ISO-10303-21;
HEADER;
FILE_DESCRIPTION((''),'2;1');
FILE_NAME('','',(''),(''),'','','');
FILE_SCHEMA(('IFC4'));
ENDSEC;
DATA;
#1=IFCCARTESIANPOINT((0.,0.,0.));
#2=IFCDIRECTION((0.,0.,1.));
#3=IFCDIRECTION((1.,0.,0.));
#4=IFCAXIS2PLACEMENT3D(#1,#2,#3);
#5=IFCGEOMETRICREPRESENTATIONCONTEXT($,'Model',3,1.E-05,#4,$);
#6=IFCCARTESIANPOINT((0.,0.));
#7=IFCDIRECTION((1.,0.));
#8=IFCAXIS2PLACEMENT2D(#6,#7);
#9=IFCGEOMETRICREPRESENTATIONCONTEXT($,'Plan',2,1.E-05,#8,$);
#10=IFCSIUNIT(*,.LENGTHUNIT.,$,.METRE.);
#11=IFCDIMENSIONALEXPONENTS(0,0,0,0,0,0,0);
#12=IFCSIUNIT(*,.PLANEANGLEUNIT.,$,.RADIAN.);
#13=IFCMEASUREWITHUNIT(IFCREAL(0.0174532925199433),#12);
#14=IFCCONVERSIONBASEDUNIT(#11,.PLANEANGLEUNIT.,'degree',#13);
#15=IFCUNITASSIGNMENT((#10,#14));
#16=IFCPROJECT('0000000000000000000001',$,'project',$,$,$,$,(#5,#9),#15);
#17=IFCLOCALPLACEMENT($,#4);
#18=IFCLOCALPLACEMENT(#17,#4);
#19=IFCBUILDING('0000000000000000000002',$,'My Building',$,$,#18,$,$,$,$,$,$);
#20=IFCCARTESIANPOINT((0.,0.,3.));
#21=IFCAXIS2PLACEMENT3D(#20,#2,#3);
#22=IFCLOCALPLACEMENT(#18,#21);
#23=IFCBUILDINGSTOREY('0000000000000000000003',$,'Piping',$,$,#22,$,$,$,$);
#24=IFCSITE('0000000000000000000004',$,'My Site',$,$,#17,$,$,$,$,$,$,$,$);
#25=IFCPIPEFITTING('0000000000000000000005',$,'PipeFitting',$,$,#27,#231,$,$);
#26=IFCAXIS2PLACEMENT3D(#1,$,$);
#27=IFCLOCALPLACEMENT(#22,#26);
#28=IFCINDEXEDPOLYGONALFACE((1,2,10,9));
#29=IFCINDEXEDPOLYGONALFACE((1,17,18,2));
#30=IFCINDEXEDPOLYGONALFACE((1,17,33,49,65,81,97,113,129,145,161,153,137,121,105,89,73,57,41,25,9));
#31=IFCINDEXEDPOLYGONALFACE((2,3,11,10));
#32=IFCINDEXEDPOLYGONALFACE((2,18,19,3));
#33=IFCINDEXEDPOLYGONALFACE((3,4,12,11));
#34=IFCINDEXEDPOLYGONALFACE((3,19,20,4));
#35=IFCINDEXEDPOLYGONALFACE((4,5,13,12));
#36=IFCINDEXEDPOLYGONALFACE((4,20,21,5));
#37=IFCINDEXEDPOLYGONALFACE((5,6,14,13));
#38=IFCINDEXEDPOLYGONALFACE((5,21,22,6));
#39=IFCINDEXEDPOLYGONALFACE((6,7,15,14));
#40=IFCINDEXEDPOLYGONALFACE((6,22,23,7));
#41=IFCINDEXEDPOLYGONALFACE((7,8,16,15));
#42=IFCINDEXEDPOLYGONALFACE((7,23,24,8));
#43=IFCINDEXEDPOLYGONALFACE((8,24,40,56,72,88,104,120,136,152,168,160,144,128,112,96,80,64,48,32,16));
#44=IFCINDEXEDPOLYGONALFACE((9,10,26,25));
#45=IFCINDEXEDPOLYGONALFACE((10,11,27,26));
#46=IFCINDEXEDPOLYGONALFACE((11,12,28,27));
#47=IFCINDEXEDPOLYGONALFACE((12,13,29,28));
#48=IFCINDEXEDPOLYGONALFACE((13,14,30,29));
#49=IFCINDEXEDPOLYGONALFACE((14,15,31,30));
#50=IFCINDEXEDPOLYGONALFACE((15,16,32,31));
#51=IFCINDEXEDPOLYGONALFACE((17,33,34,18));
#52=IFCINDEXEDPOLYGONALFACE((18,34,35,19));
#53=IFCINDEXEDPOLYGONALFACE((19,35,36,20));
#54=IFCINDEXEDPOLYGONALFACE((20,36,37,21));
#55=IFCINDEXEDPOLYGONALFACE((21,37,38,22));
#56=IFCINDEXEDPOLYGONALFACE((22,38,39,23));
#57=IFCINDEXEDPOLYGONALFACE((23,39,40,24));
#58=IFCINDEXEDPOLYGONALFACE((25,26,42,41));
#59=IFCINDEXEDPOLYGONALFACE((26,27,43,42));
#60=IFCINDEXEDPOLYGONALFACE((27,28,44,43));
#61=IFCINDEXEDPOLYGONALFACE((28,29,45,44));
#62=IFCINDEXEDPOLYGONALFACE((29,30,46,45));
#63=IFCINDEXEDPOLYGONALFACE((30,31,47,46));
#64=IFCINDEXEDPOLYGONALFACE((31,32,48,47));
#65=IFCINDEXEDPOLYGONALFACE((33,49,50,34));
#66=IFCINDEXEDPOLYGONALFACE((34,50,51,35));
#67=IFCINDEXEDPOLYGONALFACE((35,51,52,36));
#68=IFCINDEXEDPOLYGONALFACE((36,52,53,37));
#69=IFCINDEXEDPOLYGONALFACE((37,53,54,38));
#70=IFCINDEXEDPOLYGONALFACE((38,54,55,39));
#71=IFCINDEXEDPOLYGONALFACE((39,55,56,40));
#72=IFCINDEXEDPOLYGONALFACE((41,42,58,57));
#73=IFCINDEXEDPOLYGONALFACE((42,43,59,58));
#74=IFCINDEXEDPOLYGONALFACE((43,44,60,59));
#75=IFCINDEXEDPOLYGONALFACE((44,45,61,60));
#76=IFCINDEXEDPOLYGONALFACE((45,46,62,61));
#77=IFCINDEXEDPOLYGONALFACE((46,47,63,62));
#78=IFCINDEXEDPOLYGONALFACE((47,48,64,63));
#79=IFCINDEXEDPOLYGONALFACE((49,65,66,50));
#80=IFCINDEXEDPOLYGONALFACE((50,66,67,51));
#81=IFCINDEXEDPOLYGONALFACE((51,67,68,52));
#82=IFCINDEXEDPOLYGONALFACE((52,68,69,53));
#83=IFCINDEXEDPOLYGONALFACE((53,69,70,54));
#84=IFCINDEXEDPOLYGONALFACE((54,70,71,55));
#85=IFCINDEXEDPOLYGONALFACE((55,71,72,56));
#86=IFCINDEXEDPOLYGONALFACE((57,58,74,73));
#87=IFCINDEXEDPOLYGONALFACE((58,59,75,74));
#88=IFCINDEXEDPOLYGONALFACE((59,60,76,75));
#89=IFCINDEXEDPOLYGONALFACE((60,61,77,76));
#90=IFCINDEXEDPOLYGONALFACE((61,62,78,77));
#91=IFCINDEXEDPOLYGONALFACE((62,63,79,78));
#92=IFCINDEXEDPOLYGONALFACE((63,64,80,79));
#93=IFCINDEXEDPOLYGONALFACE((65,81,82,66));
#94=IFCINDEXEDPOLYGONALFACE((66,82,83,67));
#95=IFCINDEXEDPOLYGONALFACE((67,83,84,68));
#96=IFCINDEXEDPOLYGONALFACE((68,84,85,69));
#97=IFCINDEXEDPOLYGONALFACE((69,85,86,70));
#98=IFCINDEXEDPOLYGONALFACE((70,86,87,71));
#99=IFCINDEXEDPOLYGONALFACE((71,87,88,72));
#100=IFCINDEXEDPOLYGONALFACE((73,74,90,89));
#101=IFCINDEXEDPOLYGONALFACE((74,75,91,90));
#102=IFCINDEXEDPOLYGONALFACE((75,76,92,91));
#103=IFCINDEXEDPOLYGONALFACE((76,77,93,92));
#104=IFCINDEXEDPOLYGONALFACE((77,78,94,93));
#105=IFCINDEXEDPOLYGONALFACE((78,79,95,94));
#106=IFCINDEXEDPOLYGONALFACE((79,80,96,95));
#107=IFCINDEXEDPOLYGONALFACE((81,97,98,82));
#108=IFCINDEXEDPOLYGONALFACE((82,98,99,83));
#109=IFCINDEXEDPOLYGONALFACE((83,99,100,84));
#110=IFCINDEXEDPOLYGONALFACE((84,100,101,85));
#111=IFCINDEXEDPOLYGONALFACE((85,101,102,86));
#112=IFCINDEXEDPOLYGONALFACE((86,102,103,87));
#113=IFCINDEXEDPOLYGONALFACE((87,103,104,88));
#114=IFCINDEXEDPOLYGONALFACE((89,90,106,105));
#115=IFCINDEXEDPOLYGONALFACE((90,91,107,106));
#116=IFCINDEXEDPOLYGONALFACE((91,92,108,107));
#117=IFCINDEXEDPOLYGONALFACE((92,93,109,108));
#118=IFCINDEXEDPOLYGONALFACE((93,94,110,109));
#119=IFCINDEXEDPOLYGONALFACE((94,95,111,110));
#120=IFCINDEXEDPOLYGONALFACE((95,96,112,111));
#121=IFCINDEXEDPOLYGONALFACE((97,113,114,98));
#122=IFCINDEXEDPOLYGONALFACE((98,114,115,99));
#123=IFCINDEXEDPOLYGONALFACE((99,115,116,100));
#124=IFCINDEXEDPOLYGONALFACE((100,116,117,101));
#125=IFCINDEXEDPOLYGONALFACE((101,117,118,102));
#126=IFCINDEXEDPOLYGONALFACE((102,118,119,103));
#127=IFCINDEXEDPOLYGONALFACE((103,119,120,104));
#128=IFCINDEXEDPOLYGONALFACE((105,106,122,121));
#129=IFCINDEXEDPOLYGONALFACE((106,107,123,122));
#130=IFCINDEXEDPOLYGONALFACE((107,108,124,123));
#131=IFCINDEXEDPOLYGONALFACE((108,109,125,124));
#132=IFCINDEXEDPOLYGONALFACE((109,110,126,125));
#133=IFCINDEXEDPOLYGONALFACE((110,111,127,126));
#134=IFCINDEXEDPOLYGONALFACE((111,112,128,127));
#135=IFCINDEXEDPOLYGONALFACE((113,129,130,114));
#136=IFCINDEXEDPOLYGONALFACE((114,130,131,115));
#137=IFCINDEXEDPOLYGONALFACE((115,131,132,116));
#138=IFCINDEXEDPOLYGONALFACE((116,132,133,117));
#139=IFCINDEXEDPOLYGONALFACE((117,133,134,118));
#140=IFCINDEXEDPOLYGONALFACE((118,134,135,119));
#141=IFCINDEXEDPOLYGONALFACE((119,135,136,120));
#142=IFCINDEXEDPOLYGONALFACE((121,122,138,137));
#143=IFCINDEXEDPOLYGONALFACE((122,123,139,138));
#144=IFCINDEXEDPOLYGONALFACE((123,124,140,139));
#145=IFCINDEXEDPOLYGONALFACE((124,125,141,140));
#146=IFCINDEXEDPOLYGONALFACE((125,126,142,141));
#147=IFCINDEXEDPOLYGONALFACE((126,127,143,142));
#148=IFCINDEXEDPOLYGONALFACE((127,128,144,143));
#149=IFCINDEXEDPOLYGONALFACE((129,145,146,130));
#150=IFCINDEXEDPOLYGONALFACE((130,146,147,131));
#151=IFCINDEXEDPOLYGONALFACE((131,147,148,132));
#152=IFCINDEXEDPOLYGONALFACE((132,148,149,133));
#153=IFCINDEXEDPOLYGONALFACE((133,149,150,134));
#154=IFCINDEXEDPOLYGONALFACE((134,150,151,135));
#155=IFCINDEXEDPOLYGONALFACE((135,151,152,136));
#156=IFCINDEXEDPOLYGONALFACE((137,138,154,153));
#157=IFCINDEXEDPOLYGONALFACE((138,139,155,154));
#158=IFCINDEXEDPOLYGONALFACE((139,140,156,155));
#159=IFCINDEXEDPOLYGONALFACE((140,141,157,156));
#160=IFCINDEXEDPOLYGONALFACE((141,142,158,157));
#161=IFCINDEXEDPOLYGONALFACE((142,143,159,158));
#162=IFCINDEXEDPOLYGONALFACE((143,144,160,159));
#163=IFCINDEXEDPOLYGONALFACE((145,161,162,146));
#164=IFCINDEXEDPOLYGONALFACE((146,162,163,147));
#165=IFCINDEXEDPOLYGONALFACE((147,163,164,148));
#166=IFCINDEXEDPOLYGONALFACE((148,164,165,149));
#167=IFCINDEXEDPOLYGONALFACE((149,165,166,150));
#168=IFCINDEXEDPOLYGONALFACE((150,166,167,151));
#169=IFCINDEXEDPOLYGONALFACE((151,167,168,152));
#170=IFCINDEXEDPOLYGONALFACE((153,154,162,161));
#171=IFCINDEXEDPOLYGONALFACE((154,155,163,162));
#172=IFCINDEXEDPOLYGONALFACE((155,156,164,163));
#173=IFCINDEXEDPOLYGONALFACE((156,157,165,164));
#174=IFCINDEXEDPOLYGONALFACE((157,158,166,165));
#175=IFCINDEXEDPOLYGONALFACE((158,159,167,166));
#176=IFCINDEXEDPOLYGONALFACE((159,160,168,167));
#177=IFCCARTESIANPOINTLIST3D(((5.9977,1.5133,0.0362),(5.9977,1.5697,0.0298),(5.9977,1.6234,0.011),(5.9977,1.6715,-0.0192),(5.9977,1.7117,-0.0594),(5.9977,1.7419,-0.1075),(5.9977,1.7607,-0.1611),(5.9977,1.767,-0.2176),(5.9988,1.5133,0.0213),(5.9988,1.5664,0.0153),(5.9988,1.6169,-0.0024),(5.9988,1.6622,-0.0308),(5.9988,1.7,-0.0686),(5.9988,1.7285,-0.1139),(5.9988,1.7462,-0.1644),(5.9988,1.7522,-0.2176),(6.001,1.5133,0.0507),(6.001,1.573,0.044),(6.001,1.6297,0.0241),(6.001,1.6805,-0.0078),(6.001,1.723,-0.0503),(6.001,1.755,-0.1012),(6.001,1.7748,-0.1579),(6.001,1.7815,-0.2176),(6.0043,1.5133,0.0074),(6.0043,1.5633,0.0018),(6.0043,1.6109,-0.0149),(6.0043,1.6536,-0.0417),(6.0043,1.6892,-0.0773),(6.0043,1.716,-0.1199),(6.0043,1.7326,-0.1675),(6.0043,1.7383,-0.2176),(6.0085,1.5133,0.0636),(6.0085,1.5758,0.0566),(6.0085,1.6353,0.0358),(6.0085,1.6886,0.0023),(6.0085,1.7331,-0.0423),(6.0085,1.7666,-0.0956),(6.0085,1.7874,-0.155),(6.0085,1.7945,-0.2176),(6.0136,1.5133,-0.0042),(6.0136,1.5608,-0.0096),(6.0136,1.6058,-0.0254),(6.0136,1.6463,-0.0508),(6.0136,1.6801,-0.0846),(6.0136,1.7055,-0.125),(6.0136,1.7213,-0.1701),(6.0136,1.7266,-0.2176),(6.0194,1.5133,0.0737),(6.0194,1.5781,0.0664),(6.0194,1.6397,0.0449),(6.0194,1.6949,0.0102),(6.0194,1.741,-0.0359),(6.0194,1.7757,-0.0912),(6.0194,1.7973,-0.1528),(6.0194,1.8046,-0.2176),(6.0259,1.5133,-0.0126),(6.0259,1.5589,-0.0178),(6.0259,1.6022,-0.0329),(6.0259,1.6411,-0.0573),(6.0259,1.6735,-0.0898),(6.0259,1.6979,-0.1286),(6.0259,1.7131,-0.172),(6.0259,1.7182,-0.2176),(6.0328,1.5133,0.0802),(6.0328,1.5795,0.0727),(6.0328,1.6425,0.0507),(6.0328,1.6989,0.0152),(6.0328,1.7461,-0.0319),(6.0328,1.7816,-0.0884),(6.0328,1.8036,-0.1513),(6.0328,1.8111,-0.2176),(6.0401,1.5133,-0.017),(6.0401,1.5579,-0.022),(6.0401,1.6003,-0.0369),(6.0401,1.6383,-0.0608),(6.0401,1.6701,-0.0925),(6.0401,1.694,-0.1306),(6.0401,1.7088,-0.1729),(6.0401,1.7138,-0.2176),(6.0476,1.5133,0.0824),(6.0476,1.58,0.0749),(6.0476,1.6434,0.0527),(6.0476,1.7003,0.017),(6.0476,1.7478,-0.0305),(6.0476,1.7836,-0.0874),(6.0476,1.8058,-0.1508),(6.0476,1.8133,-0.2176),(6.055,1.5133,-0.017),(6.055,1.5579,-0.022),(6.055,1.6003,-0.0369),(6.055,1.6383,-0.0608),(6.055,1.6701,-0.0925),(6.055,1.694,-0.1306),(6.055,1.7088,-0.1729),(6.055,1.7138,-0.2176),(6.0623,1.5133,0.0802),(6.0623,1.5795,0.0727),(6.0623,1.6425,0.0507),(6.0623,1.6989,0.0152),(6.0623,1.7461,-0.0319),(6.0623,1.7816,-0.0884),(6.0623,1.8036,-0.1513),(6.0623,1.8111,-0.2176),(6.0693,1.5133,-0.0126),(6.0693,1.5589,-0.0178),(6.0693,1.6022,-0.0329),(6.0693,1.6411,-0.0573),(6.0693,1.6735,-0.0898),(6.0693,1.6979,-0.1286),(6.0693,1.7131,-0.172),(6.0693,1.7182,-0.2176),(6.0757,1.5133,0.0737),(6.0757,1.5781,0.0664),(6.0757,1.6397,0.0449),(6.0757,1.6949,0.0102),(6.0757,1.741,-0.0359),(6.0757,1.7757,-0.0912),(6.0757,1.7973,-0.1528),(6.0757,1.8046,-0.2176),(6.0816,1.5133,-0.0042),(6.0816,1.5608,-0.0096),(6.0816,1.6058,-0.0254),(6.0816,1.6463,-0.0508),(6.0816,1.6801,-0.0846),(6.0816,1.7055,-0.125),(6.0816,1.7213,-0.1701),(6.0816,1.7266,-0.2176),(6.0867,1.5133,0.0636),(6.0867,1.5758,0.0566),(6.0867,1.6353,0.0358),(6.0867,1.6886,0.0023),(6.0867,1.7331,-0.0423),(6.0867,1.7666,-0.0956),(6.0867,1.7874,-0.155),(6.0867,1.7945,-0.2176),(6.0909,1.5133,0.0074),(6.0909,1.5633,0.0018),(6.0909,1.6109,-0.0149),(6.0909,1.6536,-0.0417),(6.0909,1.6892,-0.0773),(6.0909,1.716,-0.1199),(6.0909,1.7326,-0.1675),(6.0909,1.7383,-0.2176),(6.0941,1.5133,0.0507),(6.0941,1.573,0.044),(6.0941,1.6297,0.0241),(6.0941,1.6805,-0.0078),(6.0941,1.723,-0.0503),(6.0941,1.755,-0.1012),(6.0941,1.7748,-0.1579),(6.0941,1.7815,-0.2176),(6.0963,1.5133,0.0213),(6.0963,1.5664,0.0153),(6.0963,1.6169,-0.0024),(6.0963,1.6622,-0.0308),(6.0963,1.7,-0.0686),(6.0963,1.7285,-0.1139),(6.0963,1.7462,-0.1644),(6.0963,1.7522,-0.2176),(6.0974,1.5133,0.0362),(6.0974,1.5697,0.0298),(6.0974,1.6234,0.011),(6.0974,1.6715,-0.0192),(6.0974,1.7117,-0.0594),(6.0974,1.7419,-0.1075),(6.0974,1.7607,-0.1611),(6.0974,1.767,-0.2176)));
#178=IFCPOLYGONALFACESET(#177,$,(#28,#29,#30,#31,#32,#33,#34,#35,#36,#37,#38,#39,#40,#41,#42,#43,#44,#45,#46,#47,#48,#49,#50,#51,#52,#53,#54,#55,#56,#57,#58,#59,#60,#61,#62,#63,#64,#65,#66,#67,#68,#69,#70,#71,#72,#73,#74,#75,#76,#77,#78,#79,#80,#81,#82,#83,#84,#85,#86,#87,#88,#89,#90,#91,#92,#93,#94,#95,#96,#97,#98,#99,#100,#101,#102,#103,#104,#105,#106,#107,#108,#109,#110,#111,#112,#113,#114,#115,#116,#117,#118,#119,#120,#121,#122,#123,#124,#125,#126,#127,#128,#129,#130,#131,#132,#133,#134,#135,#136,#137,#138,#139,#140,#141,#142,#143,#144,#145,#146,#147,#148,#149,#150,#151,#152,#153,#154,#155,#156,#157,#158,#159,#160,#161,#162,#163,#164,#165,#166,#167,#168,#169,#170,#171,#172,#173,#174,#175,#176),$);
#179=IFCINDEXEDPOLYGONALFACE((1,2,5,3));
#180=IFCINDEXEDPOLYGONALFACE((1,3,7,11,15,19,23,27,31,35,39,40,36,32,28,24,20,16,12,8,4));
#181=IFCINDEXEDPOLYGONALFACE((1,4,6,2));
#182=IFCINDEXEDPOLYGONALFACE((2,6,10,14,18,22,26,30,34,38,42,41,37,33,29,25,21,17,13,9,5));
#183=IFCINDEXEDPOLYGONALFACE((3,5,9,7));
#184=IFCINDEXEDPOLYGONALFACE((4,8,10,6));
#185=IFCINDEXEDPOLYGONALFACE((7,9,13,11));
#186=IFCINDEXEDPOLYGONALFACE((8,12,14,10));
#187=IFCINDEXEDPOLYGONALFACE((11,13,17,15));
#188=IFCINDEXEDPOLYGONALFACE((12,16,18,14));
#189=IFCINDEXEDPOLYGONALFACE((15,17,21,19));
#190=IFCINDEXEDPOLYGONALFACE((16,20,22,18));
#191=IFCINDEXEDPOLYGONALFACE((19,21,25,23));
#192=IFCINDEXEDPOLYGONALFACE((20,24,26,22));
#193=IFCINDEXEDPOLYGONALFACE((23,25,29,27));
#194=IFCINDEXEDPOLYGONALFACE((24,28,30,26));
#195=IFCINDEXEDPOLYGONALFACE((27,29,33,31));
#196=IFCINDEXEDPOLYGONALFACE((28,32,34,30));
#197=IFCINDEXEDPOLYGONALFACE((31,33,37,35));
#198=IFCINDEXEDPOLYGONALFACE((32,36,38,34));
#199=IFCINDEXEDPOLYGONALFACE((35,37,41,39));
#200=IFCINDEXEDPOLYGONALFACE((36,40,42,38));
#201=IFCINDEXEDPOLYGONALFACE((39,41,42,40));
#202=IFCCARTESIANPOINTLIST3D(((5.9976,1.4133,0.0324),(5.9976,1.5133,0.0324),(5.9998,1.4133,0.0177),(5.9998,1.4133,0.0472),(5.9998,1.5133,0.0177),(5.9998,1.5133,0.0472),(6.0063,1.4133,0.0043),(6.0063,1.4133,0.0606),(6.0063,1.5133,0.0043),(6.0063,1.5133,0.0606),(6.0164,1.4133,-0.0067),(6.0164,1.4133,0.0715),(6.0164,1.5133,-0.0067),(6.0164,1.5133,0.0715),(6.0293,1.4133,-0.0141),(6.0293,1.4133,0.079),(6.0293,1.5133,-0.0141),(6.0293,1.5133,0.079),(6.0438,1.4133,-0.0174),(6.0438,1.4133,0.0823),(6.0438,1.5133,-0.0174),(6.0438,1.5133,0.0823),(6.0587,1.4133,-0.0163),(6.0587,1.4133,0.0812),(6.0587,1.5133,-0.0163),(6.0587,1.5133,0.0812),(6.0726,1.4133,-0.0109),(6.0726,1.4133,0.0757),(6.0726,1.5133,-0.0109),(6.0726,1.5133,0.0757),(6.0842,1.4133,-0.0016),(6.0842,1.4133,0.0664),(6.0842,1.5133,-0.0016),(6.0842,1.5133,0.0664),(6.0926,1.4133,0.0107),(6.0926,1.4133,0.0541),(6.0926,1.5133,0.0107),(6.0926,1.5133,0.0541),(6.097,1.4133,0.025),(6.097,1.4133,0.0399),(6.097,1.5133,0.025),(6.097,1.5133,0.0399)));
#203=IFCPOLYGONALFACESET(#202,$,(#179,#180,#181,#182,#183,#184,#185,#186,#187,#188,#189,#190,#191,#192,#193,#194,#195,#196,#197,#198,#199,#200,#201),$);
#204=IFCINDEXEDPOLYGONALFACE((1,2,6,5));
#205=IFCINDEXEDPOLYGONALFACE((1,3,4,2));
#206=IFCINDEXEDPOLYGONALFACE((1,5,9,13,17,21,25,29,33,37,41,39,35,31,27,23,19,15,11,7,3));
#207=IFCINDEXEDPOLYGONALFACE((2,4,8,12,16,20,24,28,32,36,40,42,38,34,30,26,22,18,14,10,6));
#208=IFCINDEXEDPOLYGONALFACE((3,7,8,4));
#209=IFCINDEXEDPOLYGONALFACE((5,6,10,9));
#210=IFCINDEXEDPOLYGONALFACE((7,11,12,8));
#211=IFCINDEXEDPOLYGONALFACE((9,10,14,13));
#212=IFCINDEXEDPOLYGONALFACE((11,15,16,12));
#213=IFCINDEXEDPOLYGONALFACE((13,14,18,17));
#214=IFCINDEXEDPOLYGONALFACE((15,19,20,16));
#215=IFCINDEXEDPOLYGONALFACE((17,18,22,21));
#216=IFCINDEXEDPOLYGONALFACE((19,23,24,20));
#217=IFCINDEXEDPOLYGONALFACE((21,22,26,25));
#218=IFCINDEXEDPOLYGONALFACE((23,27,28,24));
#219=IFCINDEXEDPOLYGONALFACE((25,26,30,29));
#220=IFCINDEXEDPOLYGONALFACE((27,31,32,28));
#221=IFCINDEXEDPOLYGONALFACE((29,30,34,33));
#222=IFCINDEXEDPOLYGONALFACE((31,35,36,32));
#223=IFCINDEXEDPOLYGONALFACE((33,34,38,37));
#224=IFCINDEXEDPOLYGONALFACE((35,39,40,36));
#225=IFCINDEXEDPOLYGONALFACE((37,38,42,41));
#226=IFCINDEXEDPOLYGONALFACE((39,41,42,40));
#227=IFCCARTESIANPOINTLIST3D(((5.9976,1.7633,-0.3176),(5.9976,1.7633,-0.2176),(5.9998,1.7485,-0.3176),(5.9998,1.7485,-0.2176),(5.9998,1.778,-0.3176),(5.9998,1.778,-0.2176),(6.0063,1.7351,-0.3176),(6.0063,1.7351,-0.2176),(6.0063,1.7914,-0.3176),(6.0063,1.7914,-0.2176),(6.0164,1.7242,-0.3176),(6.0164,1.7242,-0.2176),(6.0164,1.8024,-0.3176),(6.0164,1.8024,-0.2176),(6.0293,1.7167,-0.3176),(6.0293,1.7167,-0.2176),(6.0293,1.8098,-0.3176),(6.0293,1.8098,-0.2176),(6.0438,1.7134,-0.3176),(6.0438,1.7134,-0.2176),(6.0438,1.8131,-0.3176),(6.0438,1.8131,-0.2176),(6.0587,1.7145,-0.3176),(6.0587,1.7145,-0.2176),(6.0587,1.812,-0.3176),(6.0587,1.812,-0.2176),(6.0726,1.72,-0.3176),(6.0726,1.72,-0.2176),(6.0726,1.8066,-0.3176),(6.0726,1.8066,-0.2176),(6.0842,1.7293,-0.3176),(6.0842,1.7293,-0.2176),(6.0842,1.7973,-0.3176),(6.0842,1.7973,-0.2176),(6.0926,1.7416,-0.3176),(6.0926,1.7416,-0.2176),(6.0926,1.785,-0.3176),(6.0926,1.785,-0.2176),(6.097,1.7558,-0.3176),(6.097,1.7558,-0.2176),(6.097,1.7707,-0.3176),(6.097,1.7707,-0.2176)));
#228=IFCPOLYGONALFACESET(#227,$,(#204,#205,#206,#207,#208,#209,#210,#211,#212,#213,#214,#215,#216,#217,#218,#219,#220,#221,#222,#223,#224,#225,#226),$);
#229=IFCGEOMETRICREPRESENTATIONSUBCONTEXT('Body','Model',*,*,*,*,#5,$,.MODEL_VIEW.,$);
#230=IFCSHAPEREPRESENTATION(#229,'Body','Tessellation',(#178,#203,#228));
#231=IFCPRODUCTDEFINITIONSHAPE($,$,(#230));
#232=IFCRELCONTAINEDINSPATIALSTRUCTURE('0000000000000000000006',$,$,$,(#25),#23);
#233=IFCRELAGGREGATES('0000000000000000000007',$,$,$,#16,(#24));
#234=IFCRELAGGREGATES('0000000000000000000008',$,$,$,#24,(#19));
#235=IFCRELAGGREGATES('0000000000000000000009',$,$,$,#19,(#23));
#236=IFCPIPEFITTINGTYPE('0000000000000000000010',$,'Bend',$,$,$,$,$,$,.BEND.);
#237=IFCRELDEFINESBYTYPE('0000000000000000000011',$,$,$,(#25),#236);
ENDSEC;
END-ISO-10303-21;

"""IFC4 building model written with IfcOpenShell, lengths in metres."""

from ifc_helpers import new_model, entity, si_unit, converted_unit, frame, origin_with_axes, origin_2d_with_axis, place, context, subcontext, project, spatial, circle, extrude, source, transform, mapped, type_object, type_shapes, element, save


model = new_model("IFC4")

# Units and contexts
model_context = context("Model", 3, precision=1e-05, world=origin_with_axes())
plan_context = context("Plan", 2, precision=1e-05, world=origin_2d_with_axis())
body_context = subcontext(model_context, "Body", "Model", "MODEL_VIEW")
ifc_project = project(units=[si_unit("LENGTHUNIT", "METRE"), converted_unit("PLANEANGLEUNIT", "degree", entity("IfcReal", 0.0174532925199433), si_unit("PLANEANGLEUNIT", "RADIAN"), dimensions=[0, 0, 0, 0, 0, 0, 0])], contexts=[model_context, plan_context])

# Site, building, storey
site_placement = place(None, origin_with_axes())
site = spatial("IfcSite", under=ifc_project, at=site_placement, Name="My Site")
building_placement = place(site_placement, origin_with_axes())
building = spatial("IfcBuilding", under=site, at=building_placement, Name="My Building")
storey_placement = place(building_placement, frame((0.0, 0.0, 3.0), z_axis=(0.0, 0.0, 1.0), x_axis=(1.0, 0.0, 0.0)))
storey = spatial("IfcBuildingStorey", under=building, at=storey_placement, Name="Piping")

# Pipe fitting
pipe_fitting_type_1 = type_object("IfcPipeFittingType", Name="Bend", PredefinedType="BEND")
shared_shape_1 = source(origin_with_axes(), body_context, "Body", "SolidModel", [
    entity("IfcSweptDiskSolid", entity("IfcIndexedPolyCurve", entity("IfcCartesianPointList3D", [[0.0, 0.0, 0.1], [0.0, -0.0732, 0.2768], [0.0, -0.25, 0.35]]), [entity("IfcArcIndex", [1, 2, 3])]), 0.05),
    extrude(circle(Radius=0.05), origin_with_axes(), (0.0, 0.0, 1.0), 0.1),
    extrude(circle(Radius=0.05), frame((0.0, -0.25, 0.35), z_axis=(0.0, -1.0, 0.0), x_axis=(1.0, 0.0, 0.0)), (0.0, 0.0, 1.0), 0.1),
])
type_shapes(pipe_fitting_type_1, [shared_shape_1])
for number, where, z_axis, x_axis, name in (
    (1, (6.0476, 1.4133, 0.0324), (0.0, 1.0, 0.0), (-1.0, 0.0, 0.0), "PipeFitting"),
):
    element("IfcPipeFitting", number, at=place(storey_placement, frame(where, z_axis=z_axis, x_axis=x_axis)), inside=storey, type_object=pipe_fitting_type_1, Name=name, context=body_context, shape_type="MappedRepresentation", body=[
        mapped(shared_shape_1, transform((0.0, 0.0, 0.0), x_axis=(1.0, 0.0, 0.0), y_axis=(0.0, 1.0, 0.0), z_axis=(0.0, 0.0, 1.0), scale=1.0)),
    ])

save(model, "model.ifc")
